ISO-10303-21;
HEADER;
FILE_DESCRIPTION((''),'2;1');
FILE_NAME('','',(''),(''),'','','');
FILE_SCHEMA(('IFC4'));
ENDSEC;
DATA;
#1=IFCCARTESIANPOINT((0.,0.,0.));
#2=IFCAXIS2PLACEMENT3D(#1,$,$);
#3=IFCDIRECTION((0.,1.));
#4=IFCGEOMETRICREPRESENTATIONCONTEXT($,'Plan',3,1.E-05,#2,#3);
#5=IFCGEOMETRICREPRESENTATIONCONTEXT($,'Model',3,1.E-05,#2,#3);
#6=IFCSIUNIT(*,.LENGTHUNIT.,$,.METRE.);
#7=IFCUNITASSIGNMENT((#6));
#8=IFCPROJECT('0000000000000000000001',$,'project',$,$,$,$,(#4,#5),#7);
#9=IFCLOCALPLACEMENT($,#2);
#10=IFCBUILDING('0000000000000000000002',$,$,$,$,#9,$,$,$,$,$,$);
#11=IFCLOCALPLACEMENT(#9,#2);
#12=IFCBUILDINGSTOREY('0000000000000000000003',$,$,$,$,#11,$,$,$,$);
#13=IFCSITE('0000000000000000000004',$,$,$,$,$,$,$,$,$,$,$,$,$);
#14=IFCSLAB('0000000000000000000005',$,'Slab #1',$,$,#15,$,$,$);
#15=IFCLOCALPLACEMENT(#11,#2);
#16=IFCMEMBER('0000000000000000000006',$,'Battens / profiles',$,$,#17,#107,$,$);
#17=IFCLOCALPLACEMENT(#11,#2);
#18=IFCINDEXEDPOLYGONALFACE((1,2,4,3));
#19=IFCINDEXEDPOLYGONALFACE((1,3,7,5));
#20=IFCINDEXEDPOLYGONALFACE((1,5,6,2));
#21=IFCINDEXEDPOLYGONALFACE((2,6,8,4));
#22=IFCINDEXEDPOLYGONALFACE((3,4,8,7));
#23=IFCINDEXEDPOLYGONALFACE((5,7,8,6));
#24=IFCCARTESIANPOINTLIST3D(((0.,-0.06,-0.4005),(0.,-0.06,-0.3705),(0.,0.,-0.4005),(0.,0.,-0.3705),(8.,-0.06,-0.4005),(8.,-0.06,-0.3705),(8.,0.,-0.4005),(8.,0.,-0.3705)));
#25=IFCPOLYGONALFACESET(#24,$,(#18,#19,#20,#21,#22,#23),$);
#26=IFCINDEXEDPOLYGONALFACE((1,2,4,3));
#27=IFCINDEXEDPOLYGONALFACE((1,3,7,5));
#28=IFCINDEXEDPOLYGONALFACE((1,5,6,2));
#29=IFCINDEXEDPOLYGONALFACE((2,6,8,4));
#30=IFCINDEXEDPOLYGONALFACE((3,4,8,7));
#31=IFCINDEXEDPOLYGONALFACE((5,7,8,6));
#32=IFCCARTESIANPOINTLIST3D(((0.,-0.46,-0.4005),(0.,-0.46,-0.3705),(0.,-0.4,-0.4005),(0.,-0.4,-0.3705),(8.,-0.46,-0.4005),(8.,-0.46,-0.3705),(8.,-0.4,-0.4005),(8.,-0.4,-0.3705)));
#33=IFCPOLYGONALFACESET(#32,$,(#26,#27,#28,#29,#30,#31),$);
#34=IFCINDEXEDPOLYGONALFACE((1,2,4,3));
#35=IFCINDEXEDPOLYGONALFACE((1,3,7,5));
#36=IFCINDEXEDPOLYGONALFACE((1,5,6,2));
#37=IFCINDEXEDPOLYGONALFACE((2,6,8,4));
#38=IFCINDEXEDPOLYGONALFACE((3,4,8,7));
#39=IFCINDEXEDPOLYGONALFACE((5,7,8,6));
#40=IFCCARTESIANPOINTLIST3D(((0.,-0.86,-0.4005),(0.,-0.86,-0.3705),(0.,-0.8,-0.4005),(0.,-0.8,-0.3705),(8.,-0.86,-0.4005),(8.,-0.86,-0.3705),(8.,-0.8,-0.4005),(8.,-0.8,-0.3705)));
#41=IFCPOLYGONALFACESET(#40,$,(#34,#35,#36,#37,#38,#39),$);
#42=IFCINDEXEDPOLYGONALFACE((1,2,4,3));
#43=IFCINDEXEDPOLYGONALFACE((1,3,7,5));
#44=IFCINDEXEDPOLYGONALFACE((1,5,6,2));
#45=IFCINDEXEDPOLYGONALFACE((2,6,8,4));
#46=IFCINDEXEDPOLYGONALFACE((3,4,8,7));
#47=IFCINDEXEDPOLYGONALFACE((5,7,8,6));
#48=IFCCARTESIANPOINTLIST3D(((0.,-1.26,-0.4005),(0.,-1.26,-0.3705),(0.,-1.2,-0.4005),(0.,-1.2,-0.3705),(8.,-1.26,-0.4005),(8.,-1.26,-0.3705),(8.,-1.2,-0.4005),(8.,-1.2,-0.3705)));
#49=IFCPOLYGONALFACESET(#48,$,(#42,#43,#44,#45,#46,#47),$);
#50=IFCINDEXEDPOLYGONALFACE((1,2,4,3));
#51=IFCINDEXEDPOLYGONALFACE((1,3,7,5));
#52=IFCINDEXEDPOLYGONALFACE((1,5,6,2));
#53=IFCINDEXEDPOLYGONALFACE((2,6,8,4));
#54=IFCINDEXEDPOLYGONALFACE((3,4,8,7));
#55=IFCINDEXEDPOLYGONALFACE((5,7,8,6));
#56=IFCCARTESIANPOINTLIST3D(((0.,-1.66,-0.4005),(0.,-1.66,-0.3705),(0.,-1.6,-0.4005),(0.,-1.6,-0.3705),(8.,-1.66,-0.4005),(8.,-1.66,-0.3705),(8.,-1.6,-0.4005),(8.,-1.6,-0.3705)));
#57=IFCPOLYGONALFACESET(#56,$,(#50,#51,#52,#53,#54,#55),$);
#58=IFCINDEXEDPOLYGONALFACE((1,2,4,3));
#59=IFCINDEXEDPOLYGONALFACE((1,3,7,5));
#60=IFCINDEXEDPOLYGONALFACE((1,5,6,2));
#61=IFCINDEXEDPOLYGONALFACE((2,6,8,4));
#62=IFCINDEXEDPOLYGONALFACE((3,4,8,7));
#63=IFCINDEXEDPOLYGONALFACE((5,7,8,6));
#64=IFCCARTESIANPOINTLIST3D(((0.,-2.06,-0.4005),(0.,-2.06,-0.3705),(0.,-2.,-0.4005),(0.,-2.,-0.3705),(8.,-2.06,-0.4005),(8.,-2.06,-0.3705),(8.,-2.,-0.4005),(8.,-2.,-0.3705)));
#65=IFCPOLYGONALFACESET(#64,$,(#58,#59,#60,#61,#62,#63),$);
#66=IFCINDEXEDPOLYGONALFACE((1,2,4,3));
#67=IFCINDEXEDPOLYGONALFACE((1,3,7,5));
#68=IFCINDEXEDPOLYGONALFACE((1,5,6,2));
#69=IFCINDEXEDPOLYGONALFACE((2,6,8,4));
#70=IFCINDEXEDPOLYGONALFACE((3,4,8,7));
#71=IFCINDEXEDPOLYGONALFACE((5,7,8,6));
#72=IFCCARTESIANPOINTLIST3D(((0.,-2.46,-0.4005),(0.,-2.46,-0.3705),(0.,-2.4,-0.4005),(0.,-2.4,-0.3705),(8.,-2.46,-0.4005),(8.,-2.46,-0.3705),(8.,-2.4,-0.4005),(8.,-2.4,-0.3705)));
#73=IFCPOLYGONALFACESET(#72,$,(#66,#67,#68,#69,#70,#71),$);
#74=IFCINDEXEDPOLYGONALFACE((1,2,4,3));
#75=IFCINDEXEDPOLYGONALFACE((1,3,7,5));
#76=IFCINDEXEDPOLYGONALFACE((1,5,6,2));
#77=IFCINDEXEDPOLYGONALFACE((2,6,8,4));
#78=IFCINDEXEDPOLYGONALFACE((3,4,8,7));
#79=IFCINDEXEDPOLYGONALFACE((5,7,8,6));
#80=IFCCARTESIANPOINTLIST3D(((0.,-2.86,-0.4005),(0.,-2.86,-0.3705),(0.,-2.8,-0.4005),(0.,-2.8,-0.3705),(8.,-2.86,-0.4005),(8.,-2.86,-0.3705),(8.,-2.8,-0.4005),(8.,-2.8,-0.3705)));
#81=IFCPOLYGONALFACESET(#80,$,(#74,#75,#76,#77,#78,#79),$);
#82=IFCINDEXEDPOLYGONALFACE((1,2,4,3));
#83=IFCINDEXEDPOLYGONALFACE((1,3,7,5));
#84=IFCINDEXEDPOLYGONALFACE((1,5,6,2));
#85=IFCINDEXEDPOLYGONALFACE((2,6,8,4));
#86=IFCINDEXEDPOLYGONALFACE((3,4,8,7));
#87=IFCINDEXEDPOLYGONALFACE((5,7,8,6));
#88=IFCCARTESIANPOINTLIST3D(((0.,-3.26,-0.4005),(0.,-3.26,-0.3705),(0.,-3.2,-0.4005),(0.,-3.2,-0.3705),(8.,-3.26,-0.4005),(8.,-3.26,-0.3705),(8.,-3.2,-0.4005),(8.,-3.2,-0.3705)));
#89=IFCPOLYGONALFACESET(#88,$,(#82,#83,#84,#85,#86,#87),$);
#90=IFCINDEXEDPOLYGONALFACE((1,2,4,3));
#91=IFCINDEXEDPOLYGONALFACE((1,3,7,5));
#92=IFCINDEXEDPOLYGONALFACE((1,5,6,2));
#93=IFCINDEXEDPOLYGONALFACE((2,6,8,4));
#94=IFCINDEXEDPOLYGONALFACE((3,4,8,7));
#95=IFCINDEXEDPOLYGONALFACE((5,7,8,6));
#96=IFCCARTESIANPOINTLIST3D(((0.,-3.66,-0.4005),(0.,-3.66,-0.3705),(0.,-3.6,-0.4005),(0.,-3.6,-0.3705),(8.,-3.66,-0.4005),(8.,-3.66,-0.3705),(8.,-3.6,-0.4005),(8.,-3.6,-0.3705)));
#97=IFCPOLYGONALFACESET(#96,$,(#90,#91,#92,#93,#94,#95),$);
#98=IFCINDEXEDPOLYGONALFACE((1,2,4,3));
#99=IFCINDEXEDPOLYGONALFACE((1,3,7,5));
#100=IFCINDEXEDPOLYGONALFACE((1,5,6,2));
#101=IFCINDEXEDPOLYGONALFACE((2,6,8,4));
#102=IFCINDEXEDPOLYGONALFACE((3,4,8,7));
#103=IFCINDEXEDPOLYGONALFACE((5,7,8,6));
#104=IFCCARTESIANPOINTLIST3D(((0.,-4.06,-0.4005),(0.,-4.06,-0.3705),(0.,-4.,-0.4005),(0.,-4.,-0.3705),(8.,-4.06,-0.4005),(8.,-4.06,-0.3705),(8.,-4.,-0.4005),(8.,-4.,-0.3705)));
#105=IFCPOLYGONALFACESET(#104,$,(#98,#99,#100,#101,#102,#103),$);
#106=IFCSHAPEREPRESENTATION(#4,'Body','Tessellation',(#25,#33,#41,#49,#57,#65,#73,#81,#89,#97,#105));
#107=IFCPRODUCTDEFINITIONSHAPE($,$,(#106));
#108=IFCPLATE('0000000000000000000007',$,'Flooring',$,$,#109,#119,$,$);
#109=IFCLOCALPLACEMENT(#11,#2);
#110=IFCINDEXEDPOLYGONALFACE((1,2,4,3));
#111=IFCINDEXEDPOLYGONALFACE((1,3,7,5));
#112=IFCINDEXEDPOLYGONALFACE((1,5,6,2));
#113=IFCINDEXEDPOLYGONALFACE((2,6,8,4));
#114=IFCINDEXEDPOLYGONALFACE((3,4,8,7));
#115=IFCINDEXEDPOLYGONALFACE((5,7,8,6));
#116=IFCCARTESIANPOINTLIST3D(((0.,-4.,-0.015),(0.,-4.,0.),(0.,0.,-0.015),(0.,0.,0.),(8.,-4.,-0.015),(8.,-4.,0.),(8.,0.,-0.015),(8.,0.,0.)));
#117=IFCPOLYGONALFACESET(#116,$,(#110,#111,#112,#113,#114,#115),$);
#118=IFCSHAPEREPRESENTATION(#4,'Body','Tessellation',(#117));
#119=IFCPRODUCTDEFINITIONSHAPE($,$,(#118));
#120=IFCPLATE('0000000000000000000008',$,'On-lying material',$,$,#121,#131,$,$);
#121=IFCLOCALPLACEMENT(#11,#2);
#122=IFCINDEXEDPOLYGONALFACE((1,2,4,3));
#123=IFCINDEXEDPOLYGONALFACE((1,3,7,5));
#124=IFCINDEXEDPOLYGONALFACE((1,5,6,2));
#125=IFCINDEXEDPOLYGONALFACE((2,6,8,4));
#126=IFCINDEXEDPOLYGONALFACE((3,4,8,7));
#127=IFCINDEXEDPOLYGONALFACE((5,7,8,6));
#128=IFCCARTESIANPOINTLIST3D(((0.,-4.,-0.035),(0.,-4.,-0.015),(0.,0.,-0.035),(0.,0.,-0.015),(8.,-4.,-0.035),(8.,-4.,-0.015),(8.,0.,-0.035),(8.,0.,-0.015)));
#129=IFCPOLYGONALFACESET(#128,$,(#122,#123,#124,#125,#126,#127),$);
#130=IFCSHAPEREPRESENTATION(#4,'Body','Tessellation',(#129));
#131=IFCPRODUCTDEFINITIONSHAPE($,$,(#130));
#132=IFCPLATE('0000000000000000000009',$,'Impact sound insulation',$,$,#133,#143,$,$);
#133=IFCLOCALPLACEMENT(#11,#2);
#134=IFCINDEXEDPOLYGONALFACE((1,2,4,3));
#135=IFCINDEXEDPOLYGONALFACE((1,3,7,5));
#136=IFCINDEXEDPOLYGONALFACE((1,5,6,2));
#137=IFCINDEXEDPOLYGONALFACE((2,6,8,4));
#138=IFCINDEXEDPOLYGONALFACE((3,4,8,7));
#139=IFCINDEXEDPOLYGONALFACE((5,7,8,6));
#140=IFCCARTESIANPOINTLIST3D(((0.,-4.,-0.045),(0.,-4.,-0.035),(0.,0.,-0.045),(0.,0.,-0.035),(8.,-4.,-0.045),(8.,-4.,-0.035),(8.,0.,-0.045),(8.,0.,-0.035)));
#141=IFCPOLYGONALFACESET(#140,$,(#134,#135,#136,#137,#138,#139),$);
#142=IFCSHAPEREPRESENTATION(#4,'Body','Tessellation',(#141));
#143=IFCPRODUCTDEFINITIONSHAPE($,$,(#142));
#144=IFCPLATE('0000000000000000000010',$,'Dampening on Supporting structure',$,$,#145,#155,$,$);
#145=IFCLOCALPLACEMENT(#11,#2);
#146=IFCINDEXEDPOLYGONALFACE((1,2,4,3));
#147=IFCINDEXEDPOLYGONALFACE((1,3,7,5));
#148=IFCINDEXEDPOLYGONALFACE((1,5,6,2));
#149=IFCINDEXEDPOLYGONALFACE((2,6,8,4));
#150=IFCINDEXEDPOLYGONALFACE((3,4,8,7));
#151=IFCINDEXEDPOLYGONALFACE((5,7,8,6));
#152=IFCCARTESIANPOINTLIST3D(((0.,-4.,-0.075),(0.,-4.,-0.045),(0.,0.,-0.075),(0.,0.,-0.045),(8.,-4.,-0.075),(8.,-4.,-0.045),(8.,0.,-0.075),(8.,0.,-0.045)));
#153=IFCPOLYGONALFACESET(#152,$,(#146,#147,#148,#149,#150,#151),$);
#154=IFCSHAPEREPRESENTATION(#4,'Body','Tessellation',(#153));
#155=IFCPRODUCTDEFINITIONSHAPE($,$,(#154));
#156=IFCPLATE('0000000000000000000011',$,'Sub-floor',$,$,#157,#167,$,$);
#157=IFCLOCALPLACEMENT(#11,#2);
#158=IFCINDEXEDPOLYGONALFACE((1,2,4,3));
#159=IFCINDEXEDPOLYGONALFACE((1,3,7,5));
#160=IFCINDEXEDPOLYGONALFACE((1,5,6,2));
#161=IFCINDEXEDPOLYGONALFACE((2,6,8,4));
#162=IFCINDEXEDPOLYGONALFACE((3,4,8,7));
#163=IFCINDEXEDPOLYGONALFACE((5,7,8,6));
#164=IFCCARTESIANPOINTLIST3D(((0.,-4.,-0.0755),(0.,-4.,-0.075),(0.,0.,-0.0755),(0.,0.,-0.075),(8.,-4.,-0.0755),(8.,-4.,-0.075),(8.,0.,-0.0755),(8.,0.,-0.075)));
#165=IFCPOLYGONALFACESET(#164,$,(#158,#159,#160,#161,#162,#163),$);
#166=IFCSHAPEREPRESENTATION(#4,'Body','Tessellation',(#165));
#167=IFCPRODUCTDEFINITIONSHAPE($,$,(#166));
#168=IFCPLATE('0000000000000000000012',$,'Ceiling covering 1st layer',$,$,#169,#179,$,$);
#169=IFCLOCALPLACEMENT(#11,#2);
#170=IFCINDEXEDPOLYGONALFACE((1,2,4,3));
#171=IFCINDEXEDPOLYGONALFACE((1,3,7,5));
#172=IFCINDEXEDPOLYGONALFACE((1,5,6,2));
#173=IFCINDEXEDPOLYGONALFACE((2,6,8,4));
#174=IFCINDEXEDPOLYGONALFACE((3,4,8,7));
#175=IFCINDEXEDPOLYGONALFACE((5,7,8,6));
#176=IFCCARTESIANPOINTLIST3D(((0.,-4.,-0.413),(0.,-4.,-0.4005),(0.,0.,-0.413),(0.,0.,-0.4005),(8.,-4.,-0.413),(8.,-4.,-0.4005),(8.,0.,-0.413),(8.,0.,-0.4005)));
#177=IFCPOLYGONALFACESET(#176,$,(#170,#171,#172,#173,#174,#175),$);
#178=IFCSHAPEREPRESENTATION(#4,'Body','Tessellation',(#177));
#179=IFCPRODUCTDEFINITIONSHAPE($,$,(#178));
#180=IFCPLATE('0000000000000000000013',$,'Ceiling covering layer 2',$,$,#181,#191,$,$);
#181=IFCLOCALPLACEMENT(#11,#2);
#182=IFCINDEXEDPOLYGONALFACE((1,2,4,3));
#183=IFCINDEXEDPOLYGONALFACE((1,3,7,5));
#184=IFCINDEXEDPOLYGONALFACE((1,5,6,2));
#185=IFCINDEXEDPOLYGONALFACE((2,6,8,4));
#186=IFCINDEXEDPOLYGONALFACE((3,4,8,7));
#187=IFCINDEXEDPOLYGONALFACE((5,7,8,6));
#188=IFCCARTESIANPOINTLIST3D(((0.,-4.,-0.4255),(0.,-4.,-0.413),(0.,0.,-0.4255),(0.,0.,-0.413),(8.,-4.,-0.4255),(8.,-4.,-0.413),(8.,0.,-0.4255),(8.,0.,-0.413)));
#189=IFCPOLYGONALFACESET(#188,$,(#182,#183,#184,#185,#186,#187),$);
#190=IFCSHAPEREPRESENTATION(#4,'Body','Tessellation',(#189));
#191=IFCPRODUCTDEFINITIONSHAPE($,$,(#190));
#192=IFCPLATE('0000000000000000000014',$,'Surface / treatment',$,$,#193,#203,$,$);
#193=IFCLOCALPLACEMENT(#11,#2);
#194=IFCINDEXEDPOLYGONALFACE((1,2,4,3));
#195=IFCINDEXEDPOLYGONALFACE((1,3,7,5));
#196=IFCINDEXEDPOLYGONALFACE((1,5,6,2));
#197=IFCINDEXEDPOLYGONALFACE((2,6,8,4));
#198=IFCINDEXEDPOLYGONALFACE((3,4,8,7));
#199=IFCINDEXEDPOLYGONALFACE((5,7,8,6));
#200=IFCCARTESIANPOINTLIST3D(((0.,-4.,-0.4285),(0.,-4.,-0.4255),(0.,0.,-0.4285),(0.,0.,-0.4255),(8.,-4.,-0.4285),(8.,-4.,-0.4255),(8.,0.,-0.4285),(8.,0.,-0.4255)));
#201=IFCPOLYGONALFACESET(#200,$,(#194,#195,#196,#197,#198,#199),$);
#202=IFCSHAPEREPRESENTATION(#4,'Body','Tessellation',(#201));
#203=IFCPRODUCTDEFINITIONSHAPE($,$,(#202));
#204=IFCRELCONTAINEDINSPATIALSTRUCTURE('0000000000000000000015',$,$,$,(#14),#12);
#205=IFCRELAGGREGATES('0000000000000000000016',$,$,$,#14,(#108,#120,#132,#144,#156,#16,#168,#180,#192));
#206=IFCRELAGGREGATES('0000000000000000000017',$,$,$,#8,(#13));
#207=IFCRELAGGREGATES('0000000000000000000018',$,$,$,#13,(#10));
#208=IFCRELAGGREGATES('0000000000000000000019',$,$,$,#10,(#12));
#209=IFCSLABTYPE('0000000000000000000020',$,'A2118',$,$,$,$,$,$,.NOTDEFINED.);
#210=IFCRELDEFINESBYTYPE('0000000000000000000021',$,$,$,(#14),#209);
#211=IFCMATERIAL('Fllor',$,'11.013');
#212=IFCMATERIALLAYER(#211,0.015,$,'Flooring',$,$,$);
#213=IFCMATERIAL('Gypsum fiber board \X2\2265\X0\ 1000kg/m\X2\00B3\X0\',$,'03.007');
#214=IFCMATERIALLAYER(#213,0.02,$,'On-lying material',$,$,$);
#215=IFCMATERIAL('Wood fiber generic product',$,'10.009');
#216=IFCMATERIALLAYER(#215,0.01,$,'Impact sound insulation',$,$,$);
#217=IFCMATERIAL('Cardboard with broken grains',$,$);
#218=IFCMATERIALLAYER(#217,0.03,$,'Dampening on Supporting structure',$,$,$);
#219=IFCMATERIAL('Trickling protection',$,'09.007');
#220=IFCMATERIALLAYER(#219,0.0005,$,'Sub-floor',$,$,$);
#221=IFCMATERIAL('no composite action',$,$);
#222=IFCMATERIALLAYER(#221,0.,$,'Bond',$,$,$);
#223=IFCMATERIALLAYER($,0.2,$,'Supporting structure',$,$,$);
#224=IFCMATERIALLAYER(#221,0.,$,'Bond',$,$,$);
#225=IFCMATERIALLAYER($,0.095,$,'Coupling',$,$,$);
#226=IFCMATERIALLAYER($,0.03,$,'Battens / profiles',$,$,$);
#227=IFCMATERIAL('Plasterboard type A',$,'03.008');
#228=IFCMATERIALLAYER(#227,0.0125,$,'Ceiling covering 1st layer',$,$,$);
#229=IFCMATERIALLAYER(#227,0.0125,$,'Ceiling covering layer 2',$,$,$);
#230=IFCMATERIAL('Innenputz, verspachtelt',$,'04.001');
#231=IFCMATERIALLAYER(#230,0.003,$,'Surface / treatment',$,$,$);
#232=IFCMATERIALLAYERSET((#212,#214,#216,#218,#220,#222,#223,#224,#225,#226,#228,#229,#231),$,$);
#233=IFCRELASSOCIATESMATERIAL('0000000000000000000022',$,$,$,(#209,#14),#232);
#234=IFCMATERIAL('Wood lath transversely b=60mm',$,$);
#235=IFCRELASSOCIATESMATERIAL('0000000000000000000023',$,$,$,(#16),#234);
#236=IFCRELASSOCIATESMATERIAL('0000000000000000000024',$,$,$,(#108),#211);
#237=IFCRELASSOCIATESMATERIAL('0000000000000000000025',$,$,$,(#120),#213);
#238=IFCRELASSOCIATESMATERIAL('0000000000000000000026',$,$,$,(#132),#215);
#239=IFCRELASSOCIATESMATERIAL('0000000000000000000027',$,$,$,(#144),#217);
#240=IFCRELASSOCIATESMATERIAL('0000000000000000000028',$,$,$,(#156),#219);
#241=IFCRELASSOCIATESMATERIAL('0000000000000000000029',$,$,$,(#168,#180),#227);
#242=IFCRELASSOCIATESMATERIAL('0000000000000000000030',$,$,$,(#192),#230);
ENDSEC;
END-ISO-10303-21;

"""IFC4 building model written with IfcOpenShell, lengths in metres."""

from ifc_helpers import new_model, si_unit, direction, frame, frame_2d, origin, origin_with_axes, place, context, project, spatial, rectangle, extrude, material, layer, layer_set, type_object, element, aggregate, save


model = new_model("IFC4")

# Units and contexts
plan_context = context("Plan", 3, precision=1e-05, world=origin(), true_north=direction((0.0, 1.0)))
model_context = context("Model", 3, precision=1e-05, world=origin(), true_north=direction((0.0, 1.0)))
ifc_project = project(units=[si_unit("LENGTHUNIT", "METRE")], contexts=[plan_context, model_context])

# Site, building, storey
site = spatial("IfcSite", under=ifc_project)
building_placement = place(None, origin())
building = spatial("IfcBuilding", under=site, at=building_placement)
storey_placement = place(building_placement, origin())
storey = spatial("IfcBuildingStorey", under=building, at=storey_placement)

# Slab, member, plates
ifc_material_1 = material(Name="Fllor", Category="11.013")
ifc_layer_1 = layer(ifc_material_1, 0.015, Name="Flooring")
ifc_material_2 = material(Name="Gypsum fiber board ≥ 1000kg/m³", Category="03.007")
ifc_layer_2 = layer(ifc_material_2, 0.02, Name="On-lying material")
ifc_material_3 = material(Name="Wood fiber generic product", Category="10.009")
ifc_layer_3 = layer(ifc_material_3, 0.01, Name="Impact sound insulation")
ifc_material_4 = material(Name="Cardboard with broken grains")
ifc_layer_4 = layer(ifc_material_4, 0.03, Name="Dampening on Supporting structure")
ifc_material_5 = material(Name="Trickling protection", Category="09.007")
ifc_layer_5 = layer(ifc_material_5, 0.0005, Name="Sub-floor")
ifc_material_6 = material(Name="no composite action")
ifc_layer_6 = layer(ifc_material_6, 0.0, Name="Bond")
ifc_layer_7 = layer(None, 0.2, Name="Supporting structure")
ifc_layer_8 = layer(ifc_material_6, 0.0, Name="Bond")
ifc_layer_9 = layer(None, 0.095, Name="Coupling")
ifc_layer_10 = layer(None, 0.03, Name="Battens / profiles")
ifc_material_7 = material(Name="Plasterboard type A", Category="03.008")
ifc_layer_11 = layer(ifc_material_7, 0.0125, Name="Ceiling covering 1st layer")
ifc_layer_12 = layer(ifc_material_7, 0.0125, Name="Ceiling covering layer 2")
ifc_material_8 = material(Name="Innenputz, verspachtelt", Category="04.001")
ifc_layer_13 = layer(ifc_material_8, 0.003, Name="Surface / treatment")
ifc_layer_set = layer_set([ifc_layer_1, ifc_layer_2, ifc_layer_3, ifc_layer_4, ifc_layer_5, ifc_layer_6, ifc_layer_7, ifc_layer_8, ifc_layer_9, ifc_layer_10, ifc_layer_11, ifc_layer_12, ifc_layer_13])
slab_type = type_object("IfcSlabType", Name="A2118", PredefinedType="NOTDEFINED", material=ifc_layer_set)
slab_placement = place(None, frame((0.0, 0.0, 0.0), z_axis=(0.0, 0.0, -1.0), x_axis=(1.0, 0.0, 0.0)))
slab = element("IfcSlab", 1, at=slab_placement, inside=storey, type_object=slab_type, material=ifc_layer_set, Name="Slab #1")
ifc_material_9 = material(Name="Wood lath transversely b=60mm")
member_1_placement = place(slab_placement, origin())
member_1 = element("IfcMember", 2, at=member_1_placement, material=ifc_material_9, Name="Battens / profiles", context=plan_context, shape_type="SweptSolid", body=[
    extrude(rectangle(XDim=0.06, YDim=0.03, at=frame_2d((0.03, 0.015), x_axis=(1.0, 0.0))), frame((0.0, 0.0, 0.3705), z_axis=(1.0, 0.0, 0.0), x_axis=(0.0, 1.0, 0.0)), (0.0, 0.0, 1.0), 8.0),
    extrude(rectangle(XDim=0.06, YDim=0.03, at=frame_2d((0.03, 0.015), x_axis=(1.0, 0.0))), frame((0.0, 0.4, 0.3705), z_axis=(1.0, 0.0, 0.0), x_axis=(0.0, 1.0, 0.0)), (0.0, 0.0, 1.0), 8.0),
    extrude(rectangle(XDim=0.06, YDim=0.03, at=frame_2d((0.03, 0.015), x_axis=(1.0, 0.0))), frame((0.0, 0.8, 0.3705), z_axis=(1.0, 0.0, 0.0), x_axis=(0.0, 1.0, 0.0)), (0.0, 0.0, 1.0), 8.0),
    extrude(rectangle(XDim=0.06, YDim=0.03, at=frame_2d((0.03, 0.015), x_axis=(1.0, 0.0))), frame((0.0, 1.2, 0.3705), z_axis=(1.0, 0.0, 0.0), x_axis=(0.0, 1.0, 0.0)), (0.0, 0.0, 1.0), 8.0),
    extrude(rectangle(XDim=0.06, YDim=0.03, at=frame_2d((0.03, 0.015), x_axis=(1.0, 0.0))), frame((0.0, 1.6, 0.3705), z_axis=(1.0, 0.0, 0.0), x_axis=(0.0, 1.0, 0.0)), (0.0, 0.0, 1.0), 8.0),
    extrude(rectangle(XDim=0.06, YDim=0.03, at=frame_2d((0.03, 0.015), x_axis=(1.0, 0.0))), frame((0.0, 2.0, 0.3705), z_axis=(1.0, 0.0, 0.0), x_axis=(0.0, 1.0, 0.0)), (0.0, 0.0, 1.0), 8.0),
    extrude(rectangle(XDim=0.06, YDim=0.03, at=frame_2d((0.03, 0.015), x_axis=(1.0, 0.0))), frame((0.0, 2.4, 0.3705), z_axis=(1.0, 0.0, 0.0), x_axis=(0.0, 1.0, 0.0)), (0.0, 0.0, 1.0), 8.0),
    extrude(rectangle(XDim=0.06, YDim=0.03, at=frame_2d((0.03, 0.015), x_axis=(1.0, 0.0))), frame((0.0, 2.8, 0.3705), z_axis=(1.0, 0.0, 0.0), x_axis=(0.0, 1.0, 0.0)), (0.0, 0.0, 1.0), 8.0),
    extrude(rectangle(XDim=0.06, YDim=0.03, at=frame_2d((0.03, 0.015), x_axis=(1.0, 0.0))), frame((0.0, 3.2, 0.3705), z_axis=(1.0, 0.0, 0.0), x_axis=(0.0, 1.0, 0.0)), (0.0, 0.0, 1.0), 8.0),
    extrude(rectangle(XDim=0.06, YDim=0.03, at=frame_2d((0.03, 0.015), x_axis=(1.0, 0.0))), frame((0.0, 3.6, 0.3705), z_axis=(1.0, 0.0, 0.0), x_axis=(0.0, 1.0, 0.0)), (0.0, 0.0, 1.0), 8.0),
    extrude(rectangle(XDim=0.06, YDim=0.03, at=frame_2d((0.03, 0.015), x_axis=(1.0, 0.0))), frame((0.0, 4.0, 0.3705), z_axis=(1.0, 0.0, 0.0), x_axis=(0.0, 1.0, 0.0)), (0.0, 0.0, 1.0), 8.0),
])
plate_1_placement = place(slab_placement, origin())
plate_1 = element("IfcPlate", 3, at=plate_1_placement, material=ifc_material_1, Name="Flooring", context=plan_context, shape_type="SweptSolid", body=[
    extrude(rectangle(XDim=8.0, YDim=4.0, at=frame_2d((4.0, 2.0), x_axis=(1.0, 0.0))), origin_with_axes(), (0.0, 0.0, 1.0), 0.015),
])
plate_2_placement = place(slab_placement, origin())
plate_2 = element("IfcPlate", 4, at=plate_2_placement, material=ifc_material_2, Name="On-lying material", context=plan_context, shape_type="SweptSolid", body=[
    extrude(rectangle(XDim=8.0, YDim=4.0, at=frame_2d((4.0, 2.0), x_axis=(1.0, 0.0))), frame((0.0, 0.0, 0.015), z_axis=(0.0, 0.0, 1.0), x_axis=(1.0, 0.0, 0.0)), (0.0, 0.0, 1.0), 0.02),
])
plate_3_placement = place(slab_placement, origin())
plate_3 = element("IfcPlate", 5, at=plate_3_placement, material=ifc_material_3, Name="Impact sound insulation", context=plan_context, shape_type="SweptSolid", body=[
    extrude(rectangle(XDim=8.0, YDim=4.0, at=frame_2d((4.0, 2.0), x_axis=(1.0, 0.0))), frame((0.0, 0.0, 0.035), z_axis=(0.0, 0.0, 1.0), x_axis=(1.0, 0.0, 0.0)), (0.0, 0.0, 1.0), 0.01),
])
plate_4_placement = place(slab_placement, origin())
plate_4 = element("IfcPlate", 6, at=plate_4_placement, material=ifc_material_4, Name="Dampening on Supporting structure", context=plan_context, shape_type="SweptSolid", body=[
    extrude(rectangle(XDim=8.0, YDim=4.0, at=frame_2d((4.0, 2.0), x_axis=(1.0, 0.0))), frame((0.0, 0.0, 0.045), z_axis=(0.0, 0.0, 1.0), x_axis=(1.0, 0.0, 0.0)), (0.0, 0.0, 1.0), 0.03),
])
plate_5_placement = place(slab_placement, origin())
plate_5 = element("IfcPlate", 7, at=plate_5_placement, material=ifc_material_5, Name="Sub-floor", context=plan_context, shape_type="SweptSolid", body=[
    extrude(rectangle(XDim=8.0, YDim=4.0, at=frame_2d((4.0, 2.0), x_axis=(1.0, 0.0))), frame((0.0, 0.0, 0.075), z_axis=(0.0, 0.0, 1.0), x_axis=(1.0, 0.0, 0.0)), (0.0, 0.0, 1.0), 0.0005),
])
plate_6_placement = place(slab_placement, origin())
plate_6 = element("IfcPlate", 8, at=plate_6_placement, material=ifc_material_7, Name="Ceiling covering 1st layer", context=plan_context, shape_type="SweptSolid", body=[
    extrude(rectangle(XDim=8.0, YDim=4.0, at=frame_2d((4.0, 2.0), x_axis=(1.0, 0.0))), frame((0.0, 0.0, 0.4005), z_axis=(0.0, 0.0, 1.0), x_axis=(1.0, 0.0, 0.0)), (0.0, 0.0, 1.0), 0.0125),
])
plate_7_placement = place(slab_placement, origin())
plate_7 = element("IfcPlate", 9, at=plate_7_placement, material=ifc_material_7, Name="Ceiling covering layer 2", context=plan_context, shape_type="SweptSolid", body=[
    extrude(rectangle(XDim=8.0, YDim=4.0, at=frame_2d((4.0, 2.0), x_axis=(1.0, 0.0))), frame((0.0, 0.0, 0.413), z_axis=(0.0, 0.0, 1.0), x_axis=(1.0, 0.0, 0.0)), (0.0, 0.0, 1.0), 0.0125),
])
plate_8_placement = place(slab_placement, origin())
plate_8 = element("IfcPlate", 10, at=plate_8_placement, material=ifc_material_8, Name="Surface / treatment", context=plan_context, shape_type="SweptSolid", body=[
    extrude(rectangle(XDim=8.0, YDim=4.0, at=frame_2d((4.0, 2.0), x_axis=(1.0, 0.0))), frame((0.0, 0.0, 0.4255), z_axis=(0.0, 0.0, 1.0), x_axis=(1.0, 0.0, 0.0)), (0.0, 0.0, 1.0), 0.003),
])
aggregate(slab, [plate_1, plate_2, plate_3, plate_4, plate_5, member_1, plate_6, plate_7, plate_8])

save(model, "model.ifc")
